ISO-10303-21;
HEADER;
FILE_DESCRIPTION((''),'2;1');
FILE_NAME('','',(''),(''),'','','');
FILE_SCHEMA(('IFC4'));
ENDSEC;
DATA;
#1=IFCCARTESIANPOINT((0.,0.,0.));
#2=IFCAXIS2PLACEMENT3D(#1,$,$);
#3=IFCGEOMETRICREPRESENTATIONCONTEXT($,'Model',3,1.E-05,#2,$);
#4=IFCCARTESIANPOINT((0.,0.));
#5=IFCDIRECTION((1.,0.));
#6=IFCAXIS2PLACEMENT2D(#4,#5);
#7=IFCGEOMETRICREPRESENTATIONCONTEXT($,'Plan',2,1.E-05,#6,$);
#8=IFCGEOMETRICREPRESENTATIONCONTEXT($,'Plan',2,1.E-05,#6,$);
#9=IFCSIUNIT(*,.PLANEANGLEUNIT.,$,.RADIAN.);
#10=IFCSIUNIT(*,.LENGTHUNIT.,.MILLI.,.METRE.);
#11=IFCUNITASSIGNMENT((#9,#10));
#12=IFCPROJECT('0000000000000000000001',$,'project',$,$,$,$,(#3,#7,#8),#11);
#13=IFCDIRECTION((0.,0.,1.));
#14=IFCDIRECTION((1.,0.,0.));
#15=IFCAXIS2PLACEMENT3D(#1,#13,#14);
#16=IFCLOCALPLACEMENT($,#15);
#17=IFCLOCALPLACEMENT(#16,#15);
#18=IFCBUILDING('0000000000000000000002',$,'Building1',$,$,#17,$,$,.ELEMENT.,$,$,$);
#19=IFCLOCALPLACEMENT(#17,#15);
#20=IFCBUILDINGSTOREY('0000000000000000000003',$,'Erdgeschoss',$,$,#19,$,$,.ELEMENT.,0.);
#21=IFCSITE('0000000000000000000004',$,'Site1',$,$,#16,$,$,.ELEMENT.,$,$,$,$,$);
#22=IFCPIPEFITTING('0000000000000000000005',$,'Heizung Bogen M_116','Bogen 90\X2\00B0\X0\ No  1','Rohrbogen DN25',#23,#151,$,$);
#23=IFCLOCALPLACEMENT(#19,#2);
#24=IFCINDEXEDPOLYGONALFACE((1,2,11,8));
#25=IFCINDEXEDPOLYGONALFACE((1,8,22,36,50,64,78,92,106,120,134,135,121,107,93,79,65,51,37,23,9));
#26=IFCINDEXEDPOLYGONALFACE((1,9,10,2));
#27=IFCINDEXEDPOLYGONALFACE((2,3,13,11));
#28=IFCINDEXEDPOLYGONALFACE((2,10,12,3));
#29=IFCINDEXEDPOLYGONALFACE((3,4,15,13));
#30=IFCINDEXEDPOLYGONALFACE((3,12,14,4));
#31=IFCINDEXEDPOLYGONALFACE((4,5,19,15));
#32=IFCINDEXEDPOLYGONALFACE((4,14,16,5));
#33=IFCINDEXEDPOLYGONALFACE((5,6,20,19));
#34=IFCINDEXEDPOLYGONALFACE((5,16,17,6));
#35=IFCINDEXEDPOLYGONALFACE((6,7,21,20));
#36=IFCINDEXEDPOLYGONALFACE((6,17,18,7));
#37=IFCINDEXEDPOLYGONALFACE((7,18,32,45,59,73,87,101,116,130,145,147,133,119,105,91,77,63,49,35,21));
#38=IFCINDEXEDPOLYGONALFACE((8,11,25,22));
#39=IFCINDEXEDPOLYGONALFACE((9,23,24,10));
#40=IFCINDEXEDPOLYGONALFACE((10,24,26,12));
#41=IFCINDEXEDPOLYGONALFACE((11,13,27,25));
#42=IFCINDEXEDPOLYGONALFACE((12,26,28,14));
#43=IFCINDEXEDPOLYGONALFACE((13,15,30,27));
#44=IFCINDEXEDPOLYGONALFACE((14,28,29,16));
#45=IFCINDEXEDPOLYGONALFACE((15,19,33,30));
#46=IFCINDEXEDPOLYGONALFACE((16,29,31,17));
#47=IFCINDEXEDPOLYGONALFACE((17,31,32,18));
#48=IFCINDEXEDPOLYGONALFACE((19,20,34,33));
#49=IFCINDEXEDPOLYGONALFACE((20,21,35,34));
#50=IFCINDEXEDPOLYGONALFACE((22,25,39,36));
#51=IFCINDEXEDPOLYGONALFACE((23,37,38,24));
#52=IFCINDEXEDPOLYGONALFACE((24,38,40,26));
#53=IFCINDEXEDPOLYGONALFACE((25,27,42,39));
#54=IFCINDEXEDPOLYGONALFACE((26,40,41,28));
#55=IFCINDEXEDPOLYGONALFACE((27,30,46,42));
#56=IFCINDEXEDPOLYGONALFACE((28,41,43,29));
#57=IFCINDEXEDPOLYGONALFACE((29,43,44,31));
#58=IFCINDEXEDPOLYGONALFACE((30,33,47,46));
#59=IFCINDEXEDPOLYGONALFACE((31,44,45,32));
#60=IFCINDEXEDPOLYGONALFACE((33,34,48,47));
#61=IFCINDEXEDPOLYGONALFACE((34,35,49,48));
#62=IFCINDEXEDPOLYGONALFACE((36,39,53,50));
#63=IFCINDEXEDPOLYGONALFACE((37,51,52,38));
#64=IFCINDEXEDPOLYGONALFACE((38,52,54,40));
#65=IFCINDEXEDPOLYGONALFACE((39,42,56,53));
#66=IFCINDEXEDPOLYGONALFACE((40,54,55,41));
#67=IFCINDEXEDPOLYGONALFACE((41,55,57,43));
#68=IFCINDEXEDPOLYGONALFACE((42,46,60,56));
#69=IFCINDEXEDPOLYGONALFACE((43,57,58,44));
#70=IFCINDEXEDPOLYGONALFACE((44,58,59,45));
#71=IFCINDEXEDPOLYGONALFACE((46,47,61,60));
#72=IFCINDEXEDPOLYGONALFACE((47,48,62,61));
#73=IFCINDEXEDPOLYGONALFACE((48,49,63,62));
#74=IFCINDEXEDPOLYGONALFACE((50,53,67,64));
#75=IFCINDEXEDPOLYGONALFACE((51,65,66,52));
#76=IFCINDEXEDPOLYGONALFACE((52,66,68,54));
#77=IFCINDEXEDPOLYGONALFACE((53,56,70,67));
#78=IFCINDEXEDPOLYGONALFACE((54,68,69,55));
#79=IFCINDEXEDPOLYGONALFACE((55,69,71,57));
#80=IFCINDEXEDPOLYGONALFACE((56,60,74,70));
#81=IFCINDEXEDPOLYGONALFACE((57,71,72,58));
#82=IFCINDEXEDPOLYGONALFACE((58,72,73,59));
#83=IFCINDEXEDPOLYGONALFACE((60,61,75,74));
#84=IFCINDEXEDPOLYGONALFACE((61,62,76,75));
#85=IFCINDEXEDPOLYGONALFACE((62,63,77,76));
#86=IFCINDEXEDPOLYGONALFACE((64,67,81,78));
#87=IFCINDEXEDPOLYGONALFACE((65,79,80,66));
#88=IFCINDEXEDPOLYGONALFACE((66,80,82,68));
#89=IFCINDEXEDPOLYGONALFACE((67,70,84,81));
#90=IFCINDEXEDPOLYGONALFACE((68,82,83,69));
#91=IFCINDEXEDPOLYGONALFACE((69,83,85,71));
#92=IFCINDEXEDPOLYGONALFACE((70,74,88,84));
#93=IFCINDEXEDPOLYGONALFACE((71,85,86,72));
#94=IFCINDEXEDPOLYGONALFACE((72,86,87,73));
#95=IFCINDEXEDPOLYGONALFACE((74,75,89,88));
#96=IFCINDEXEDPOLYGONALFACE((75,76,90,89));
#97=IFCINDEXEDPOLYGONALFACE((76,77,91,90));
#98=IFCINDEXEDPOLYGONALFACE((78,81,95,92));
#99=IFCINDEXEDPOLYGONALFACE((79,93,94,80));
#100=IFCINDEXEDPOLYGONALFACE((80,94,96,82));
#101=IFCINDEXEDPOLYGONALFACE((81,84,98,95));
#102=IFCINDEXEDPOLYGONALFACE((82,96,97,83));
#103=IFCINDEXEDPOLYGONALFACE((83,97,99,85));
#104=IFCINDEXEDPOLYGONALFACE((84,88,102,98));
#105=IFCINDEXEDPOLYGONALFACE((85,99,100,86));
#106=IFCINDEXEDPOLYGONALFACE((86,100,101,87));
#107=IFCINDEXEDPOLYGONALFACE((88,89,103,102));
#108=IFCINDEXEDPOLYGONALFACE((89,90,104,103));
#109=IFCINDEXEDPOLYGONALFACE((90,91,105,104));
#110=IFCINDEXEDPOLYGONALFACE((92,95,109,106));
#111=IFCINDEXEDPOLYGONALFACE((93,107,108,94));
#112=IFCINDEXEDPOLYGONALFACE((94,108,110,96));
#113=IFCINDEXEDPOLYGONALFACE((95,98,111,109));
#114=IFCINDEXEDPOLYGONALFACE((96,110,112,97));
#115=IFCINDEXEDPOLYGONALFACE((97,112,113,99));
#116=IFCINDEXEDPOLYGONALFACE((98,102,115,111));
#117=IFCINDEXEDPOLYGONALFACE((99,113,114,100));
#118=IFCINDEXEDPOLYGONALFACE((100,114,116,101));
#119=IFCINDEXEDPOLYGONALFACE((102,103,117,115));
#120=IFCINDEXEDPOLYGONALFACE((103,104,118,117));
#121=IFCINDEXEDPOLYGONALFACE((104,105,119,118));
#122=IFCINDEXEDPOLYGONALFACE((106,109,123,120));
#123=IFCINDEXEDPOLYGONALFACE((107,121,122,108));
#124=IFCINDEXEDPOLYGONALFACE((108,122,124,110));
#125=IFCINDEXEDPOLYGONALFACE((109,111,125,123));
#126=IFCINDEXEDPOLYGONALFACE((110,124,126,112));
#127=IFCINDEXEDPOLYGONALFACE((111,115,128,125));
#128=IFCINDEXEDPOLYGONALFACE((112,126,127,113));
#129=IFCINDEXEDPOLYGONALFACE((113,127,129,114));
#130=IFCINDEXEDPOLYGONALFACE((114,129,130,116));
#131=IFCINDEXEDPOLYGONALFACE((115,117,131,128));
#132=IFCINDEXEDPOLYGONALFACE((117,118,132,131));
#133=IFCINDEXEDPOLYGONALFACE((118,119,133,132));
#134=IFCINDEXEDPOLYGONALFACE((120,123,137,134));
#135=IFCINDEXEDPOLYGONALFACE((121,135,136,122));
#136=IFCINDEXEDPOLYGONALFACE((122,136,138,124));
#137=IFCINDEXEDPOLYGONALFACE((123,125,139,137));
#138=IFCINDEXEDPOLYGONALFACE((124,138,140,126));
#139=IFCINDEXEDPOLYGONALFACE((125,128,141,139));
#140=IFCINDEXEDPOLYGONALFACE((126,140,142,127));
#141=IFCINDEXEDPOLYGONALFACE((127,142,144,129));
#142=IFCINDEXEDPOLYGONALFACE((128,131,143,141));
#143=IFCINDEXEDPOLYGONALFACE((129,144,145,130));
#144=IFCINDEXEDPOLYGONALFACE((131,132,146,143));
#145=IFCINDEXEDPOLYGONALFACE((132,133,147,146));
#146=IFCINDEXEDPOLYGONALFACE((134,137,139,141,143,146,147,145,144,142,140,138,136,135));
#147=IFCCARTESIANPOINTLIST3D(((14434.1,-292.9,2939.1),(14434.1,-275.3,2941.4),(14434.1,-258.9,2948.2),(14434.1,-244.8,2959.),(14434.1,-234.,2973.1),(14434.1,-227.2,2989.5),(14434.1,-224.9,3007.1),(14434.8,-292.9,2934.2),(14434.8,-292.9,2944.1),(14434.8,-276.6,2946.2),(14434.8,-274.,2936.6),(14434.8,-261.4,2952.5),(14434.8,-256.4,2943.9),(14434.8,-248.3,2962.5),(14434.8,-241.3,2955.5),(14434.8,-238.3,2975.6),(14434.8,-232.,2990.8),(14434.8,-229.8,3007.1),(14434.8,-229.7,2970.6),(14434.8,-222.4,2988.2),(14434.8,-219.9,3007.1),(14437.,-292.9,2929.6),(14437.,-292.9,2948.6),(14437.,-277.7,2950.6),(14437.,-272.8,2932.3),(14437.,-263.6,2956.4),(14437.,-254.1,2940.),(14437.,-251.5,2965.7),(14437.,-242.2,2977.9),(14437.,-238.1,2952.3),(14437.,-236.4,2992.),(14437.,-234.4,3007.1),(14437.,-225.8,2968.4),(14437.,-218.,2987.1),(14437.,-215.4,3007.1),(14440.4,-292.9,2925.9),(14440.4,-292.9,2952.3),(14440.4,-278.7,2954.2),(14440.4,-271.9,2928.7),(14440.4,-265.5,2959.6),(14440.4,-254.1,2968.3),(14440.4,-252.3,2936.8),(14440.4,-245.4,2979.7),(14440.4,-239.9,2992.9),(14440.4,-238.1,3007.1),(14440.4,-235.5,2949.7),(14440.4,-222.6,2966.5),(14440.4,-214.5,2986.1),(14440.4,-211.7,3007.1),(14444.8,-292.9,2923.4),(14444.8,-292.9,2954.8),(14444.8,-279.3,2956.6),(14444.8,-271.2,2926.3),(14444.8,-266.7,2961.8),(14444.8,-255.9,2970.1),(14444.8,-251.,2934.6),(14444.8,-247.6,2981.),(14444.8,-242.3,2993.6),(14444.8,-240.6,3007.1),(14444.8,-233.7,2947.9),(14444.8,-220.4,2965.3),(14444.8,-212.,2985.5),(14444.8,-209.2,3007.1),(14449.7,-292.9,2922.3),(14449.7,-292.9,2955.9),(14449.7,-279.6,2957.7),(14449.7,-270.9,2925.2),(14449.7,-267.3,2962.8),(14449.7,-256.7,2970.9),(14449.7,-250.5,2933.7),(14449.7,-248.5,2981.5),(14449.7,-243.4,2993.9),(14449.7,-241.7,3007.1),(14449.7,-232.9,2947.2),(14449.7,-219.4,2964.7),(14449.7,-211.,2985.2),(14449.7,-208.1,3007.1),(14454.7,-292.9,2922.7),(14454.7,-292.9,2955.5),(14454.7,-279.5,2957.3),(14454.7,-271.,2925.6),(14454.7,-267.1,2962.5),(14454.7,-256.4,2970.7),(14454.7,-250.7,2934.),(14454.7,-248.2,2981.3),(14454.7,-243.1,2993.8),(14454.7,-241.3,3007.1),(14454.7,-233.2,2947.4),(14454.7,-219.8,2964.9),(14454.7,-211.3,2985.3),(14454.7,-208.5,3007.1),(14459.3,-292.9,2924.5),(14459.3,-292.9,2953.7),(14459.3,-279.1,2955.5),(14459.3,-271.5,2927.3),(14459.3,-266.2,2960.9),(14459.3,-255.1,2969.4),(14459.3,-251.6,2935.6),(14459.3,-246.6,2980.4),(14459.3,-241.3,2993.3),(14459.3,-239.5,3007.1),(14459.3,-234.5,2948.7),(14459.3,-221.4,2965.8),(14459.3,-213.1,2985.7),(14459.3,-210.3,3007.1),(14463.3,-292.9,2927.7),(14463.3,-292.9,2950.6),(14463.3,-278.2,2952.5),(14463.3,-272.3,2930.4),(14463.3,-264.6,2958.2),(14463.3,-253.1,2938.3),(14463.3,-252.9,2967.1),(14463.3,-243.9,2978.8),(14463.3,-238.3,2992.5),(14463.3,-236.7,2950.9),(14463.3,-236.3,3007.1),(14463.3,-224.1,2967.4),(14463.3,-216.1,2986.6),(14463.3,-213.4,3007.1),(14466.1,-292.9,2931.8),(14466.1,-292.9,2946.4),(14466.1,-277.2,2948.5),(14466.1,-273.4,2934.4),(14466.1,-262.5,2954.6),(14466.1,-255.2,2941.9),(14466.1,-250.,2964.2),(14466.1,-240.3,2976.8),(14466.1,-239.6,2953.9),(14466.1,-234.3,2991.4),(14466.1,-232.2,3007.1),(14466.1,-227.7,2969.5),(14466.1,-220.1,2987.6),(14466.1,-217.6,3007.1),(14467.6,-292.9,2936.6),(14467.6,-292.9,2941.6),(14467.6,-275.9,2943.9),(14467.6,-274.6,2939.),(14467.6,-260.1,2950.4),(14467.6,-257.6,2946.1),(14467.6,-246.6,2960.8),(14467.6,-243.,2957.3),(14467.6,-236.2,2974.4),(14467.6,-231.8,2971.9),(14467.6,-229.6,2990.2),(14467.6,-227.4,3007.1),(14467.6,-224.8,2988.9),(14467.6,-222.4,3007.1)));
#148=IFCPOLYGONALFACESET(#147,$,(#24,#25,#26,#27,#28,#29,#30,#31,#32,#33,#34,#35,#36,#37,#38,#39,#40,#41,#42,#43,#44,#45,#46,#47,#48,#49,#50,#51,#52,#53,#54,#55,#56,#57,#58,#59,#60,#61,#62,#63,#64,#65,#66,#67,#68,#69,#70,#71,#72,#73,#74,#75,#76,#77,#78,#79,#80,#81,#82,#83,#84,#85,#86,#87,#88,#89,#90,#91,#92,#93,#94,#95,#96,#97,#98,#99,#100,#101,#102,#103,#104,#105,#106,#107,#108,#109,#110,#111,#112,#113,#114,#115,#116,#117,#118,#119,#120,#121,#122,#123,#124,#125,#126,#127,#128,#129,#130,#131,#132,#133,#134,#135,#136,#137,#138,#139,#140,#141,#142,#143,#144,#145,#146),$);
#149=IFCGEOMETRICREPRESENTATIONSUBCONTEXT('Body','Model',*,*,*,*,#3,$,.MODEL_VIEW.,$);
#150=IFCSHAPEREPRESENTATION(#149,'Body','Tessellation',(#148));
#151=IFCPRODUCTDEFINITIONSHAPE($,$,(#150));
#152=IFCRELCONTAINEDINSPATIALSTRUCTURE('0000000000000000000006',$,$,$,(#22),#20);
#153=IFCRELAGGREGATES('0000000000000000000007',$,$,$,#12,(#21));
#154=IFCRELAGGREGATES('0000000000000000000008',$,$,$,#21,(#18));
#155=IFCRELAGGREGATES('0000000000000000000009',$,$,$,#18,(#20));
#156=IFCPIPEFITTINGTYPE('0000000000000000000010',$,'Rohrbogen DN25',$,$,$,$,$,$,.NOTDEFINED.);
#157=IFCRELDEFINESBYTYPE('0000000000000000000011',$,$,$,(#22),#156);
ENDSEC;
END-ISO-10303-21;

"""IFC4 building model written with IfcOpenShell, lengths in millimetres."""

from ifc_helpers import new_model, entity, si_unit, frame, origin, origin_with_axes, origin_2d_with_axis, place, context, subcontext, project, spatial, source, transform, mapped, type_object, element, save


model = new_model("IFC4")

# Units and contexts
model_context = context("Model", 3, precision=1e-05, world=origin())
plan_context_1 = context("Plan", 2, precision=1e-05, world=origin_2d_with_axis())
plan_context_2 = context("Plan", 2, precision=1e-05, world=origin_2d_with_axis())
body_context = subcontext(model_context, "Body", "Model", "MODEL_VIEW")
ifc_project = project(units=[si_unit("PLANEANGLEUNIT", "RADIAN"), si_unit("LENGTHUNIT", "METRE", prefix="MILLI")], contexts=[model_context, plan_context_1, plan_context_2])

# Site, building, storey
site_placement = place(None, origin_with_axes())
site = spatial("IfcSite", under=ifc_project, at=site_placement, Name="Site1", CompositionType="ELEMENT")
building_placement = place(site_placement, origin_with_axes())
building = spatial("IfcBuilding", under=site, at=building_placement, Name="Building1", CompositionType="ELEMENT")
storey_placement = place(building_placement, origin_with_axes())
storey = spatial("IfcBuildingStorey", under=building, at=storey_placement, Name="Erdgeschoss", CompositionType="ELEMENT", Elevation=0.0)

# Pipe fitting
pipe_fitting_type = type_object("IfcPipeFittingType", Name="Rohrbogen DN25", PredefinedType="NOTDEFINED")
shared_shape_1 = source(origin_with_axes(), body_context, "Body", "SolidModel", [
    entity("IfcRevolvedAreaSolid", entity("IfcCircleProfileDef", "AREA", None, entity("IfcAxis2Placement2D", entity("IfcCartesianPoint", [0.0, 0.0]), entity("IfcDirection", [1.0, 0.0])), 16.9), entity("IfcAxis2Placement3D", entity("IfcCartesianPoint", [-42.4, 0.0, -25.6]), entity("IfcDirection", [1.0, 0.0, 0.0]), entity("IfcDirection", [0.0, 1.0, 0.0])), entity("IfcAxis1Placement", entity("IfcCartesianPoint", [0.0, 68.0, 0.0]), entity("IfcDirection", [-1.0, 0.0, 0.0])), 1.570796),
])
pipe_fitting_1_placement = place(storey_placement, frame((14450.9, -250.5, 2964.7), z_axis=(0.0, 0.0, 1.0), x_axis=(1.0, 0.0, 0.0)))
element("IfcPipeFitting", 1, at=pipe_fitting_1_placement, inside=storey, type_object=pipe_fitting_type, Name="Heizung Bogen M_116", Description="Bogen 90° No  1", ObjectType="Rohrbogen DN25", context=body_context, shape_type="MappedRepresentation", body=[
    mapped(shared_shape_1, transform((0.0, 0.0, 0.0), x_axis=(0.0, 1.0, 0.0), y_axis=(-1.0, 0.0, 0.0), z_axis=(0.0, 0.0, 1.0), scale=1.0)),
])

save(model, "model.ifc")
